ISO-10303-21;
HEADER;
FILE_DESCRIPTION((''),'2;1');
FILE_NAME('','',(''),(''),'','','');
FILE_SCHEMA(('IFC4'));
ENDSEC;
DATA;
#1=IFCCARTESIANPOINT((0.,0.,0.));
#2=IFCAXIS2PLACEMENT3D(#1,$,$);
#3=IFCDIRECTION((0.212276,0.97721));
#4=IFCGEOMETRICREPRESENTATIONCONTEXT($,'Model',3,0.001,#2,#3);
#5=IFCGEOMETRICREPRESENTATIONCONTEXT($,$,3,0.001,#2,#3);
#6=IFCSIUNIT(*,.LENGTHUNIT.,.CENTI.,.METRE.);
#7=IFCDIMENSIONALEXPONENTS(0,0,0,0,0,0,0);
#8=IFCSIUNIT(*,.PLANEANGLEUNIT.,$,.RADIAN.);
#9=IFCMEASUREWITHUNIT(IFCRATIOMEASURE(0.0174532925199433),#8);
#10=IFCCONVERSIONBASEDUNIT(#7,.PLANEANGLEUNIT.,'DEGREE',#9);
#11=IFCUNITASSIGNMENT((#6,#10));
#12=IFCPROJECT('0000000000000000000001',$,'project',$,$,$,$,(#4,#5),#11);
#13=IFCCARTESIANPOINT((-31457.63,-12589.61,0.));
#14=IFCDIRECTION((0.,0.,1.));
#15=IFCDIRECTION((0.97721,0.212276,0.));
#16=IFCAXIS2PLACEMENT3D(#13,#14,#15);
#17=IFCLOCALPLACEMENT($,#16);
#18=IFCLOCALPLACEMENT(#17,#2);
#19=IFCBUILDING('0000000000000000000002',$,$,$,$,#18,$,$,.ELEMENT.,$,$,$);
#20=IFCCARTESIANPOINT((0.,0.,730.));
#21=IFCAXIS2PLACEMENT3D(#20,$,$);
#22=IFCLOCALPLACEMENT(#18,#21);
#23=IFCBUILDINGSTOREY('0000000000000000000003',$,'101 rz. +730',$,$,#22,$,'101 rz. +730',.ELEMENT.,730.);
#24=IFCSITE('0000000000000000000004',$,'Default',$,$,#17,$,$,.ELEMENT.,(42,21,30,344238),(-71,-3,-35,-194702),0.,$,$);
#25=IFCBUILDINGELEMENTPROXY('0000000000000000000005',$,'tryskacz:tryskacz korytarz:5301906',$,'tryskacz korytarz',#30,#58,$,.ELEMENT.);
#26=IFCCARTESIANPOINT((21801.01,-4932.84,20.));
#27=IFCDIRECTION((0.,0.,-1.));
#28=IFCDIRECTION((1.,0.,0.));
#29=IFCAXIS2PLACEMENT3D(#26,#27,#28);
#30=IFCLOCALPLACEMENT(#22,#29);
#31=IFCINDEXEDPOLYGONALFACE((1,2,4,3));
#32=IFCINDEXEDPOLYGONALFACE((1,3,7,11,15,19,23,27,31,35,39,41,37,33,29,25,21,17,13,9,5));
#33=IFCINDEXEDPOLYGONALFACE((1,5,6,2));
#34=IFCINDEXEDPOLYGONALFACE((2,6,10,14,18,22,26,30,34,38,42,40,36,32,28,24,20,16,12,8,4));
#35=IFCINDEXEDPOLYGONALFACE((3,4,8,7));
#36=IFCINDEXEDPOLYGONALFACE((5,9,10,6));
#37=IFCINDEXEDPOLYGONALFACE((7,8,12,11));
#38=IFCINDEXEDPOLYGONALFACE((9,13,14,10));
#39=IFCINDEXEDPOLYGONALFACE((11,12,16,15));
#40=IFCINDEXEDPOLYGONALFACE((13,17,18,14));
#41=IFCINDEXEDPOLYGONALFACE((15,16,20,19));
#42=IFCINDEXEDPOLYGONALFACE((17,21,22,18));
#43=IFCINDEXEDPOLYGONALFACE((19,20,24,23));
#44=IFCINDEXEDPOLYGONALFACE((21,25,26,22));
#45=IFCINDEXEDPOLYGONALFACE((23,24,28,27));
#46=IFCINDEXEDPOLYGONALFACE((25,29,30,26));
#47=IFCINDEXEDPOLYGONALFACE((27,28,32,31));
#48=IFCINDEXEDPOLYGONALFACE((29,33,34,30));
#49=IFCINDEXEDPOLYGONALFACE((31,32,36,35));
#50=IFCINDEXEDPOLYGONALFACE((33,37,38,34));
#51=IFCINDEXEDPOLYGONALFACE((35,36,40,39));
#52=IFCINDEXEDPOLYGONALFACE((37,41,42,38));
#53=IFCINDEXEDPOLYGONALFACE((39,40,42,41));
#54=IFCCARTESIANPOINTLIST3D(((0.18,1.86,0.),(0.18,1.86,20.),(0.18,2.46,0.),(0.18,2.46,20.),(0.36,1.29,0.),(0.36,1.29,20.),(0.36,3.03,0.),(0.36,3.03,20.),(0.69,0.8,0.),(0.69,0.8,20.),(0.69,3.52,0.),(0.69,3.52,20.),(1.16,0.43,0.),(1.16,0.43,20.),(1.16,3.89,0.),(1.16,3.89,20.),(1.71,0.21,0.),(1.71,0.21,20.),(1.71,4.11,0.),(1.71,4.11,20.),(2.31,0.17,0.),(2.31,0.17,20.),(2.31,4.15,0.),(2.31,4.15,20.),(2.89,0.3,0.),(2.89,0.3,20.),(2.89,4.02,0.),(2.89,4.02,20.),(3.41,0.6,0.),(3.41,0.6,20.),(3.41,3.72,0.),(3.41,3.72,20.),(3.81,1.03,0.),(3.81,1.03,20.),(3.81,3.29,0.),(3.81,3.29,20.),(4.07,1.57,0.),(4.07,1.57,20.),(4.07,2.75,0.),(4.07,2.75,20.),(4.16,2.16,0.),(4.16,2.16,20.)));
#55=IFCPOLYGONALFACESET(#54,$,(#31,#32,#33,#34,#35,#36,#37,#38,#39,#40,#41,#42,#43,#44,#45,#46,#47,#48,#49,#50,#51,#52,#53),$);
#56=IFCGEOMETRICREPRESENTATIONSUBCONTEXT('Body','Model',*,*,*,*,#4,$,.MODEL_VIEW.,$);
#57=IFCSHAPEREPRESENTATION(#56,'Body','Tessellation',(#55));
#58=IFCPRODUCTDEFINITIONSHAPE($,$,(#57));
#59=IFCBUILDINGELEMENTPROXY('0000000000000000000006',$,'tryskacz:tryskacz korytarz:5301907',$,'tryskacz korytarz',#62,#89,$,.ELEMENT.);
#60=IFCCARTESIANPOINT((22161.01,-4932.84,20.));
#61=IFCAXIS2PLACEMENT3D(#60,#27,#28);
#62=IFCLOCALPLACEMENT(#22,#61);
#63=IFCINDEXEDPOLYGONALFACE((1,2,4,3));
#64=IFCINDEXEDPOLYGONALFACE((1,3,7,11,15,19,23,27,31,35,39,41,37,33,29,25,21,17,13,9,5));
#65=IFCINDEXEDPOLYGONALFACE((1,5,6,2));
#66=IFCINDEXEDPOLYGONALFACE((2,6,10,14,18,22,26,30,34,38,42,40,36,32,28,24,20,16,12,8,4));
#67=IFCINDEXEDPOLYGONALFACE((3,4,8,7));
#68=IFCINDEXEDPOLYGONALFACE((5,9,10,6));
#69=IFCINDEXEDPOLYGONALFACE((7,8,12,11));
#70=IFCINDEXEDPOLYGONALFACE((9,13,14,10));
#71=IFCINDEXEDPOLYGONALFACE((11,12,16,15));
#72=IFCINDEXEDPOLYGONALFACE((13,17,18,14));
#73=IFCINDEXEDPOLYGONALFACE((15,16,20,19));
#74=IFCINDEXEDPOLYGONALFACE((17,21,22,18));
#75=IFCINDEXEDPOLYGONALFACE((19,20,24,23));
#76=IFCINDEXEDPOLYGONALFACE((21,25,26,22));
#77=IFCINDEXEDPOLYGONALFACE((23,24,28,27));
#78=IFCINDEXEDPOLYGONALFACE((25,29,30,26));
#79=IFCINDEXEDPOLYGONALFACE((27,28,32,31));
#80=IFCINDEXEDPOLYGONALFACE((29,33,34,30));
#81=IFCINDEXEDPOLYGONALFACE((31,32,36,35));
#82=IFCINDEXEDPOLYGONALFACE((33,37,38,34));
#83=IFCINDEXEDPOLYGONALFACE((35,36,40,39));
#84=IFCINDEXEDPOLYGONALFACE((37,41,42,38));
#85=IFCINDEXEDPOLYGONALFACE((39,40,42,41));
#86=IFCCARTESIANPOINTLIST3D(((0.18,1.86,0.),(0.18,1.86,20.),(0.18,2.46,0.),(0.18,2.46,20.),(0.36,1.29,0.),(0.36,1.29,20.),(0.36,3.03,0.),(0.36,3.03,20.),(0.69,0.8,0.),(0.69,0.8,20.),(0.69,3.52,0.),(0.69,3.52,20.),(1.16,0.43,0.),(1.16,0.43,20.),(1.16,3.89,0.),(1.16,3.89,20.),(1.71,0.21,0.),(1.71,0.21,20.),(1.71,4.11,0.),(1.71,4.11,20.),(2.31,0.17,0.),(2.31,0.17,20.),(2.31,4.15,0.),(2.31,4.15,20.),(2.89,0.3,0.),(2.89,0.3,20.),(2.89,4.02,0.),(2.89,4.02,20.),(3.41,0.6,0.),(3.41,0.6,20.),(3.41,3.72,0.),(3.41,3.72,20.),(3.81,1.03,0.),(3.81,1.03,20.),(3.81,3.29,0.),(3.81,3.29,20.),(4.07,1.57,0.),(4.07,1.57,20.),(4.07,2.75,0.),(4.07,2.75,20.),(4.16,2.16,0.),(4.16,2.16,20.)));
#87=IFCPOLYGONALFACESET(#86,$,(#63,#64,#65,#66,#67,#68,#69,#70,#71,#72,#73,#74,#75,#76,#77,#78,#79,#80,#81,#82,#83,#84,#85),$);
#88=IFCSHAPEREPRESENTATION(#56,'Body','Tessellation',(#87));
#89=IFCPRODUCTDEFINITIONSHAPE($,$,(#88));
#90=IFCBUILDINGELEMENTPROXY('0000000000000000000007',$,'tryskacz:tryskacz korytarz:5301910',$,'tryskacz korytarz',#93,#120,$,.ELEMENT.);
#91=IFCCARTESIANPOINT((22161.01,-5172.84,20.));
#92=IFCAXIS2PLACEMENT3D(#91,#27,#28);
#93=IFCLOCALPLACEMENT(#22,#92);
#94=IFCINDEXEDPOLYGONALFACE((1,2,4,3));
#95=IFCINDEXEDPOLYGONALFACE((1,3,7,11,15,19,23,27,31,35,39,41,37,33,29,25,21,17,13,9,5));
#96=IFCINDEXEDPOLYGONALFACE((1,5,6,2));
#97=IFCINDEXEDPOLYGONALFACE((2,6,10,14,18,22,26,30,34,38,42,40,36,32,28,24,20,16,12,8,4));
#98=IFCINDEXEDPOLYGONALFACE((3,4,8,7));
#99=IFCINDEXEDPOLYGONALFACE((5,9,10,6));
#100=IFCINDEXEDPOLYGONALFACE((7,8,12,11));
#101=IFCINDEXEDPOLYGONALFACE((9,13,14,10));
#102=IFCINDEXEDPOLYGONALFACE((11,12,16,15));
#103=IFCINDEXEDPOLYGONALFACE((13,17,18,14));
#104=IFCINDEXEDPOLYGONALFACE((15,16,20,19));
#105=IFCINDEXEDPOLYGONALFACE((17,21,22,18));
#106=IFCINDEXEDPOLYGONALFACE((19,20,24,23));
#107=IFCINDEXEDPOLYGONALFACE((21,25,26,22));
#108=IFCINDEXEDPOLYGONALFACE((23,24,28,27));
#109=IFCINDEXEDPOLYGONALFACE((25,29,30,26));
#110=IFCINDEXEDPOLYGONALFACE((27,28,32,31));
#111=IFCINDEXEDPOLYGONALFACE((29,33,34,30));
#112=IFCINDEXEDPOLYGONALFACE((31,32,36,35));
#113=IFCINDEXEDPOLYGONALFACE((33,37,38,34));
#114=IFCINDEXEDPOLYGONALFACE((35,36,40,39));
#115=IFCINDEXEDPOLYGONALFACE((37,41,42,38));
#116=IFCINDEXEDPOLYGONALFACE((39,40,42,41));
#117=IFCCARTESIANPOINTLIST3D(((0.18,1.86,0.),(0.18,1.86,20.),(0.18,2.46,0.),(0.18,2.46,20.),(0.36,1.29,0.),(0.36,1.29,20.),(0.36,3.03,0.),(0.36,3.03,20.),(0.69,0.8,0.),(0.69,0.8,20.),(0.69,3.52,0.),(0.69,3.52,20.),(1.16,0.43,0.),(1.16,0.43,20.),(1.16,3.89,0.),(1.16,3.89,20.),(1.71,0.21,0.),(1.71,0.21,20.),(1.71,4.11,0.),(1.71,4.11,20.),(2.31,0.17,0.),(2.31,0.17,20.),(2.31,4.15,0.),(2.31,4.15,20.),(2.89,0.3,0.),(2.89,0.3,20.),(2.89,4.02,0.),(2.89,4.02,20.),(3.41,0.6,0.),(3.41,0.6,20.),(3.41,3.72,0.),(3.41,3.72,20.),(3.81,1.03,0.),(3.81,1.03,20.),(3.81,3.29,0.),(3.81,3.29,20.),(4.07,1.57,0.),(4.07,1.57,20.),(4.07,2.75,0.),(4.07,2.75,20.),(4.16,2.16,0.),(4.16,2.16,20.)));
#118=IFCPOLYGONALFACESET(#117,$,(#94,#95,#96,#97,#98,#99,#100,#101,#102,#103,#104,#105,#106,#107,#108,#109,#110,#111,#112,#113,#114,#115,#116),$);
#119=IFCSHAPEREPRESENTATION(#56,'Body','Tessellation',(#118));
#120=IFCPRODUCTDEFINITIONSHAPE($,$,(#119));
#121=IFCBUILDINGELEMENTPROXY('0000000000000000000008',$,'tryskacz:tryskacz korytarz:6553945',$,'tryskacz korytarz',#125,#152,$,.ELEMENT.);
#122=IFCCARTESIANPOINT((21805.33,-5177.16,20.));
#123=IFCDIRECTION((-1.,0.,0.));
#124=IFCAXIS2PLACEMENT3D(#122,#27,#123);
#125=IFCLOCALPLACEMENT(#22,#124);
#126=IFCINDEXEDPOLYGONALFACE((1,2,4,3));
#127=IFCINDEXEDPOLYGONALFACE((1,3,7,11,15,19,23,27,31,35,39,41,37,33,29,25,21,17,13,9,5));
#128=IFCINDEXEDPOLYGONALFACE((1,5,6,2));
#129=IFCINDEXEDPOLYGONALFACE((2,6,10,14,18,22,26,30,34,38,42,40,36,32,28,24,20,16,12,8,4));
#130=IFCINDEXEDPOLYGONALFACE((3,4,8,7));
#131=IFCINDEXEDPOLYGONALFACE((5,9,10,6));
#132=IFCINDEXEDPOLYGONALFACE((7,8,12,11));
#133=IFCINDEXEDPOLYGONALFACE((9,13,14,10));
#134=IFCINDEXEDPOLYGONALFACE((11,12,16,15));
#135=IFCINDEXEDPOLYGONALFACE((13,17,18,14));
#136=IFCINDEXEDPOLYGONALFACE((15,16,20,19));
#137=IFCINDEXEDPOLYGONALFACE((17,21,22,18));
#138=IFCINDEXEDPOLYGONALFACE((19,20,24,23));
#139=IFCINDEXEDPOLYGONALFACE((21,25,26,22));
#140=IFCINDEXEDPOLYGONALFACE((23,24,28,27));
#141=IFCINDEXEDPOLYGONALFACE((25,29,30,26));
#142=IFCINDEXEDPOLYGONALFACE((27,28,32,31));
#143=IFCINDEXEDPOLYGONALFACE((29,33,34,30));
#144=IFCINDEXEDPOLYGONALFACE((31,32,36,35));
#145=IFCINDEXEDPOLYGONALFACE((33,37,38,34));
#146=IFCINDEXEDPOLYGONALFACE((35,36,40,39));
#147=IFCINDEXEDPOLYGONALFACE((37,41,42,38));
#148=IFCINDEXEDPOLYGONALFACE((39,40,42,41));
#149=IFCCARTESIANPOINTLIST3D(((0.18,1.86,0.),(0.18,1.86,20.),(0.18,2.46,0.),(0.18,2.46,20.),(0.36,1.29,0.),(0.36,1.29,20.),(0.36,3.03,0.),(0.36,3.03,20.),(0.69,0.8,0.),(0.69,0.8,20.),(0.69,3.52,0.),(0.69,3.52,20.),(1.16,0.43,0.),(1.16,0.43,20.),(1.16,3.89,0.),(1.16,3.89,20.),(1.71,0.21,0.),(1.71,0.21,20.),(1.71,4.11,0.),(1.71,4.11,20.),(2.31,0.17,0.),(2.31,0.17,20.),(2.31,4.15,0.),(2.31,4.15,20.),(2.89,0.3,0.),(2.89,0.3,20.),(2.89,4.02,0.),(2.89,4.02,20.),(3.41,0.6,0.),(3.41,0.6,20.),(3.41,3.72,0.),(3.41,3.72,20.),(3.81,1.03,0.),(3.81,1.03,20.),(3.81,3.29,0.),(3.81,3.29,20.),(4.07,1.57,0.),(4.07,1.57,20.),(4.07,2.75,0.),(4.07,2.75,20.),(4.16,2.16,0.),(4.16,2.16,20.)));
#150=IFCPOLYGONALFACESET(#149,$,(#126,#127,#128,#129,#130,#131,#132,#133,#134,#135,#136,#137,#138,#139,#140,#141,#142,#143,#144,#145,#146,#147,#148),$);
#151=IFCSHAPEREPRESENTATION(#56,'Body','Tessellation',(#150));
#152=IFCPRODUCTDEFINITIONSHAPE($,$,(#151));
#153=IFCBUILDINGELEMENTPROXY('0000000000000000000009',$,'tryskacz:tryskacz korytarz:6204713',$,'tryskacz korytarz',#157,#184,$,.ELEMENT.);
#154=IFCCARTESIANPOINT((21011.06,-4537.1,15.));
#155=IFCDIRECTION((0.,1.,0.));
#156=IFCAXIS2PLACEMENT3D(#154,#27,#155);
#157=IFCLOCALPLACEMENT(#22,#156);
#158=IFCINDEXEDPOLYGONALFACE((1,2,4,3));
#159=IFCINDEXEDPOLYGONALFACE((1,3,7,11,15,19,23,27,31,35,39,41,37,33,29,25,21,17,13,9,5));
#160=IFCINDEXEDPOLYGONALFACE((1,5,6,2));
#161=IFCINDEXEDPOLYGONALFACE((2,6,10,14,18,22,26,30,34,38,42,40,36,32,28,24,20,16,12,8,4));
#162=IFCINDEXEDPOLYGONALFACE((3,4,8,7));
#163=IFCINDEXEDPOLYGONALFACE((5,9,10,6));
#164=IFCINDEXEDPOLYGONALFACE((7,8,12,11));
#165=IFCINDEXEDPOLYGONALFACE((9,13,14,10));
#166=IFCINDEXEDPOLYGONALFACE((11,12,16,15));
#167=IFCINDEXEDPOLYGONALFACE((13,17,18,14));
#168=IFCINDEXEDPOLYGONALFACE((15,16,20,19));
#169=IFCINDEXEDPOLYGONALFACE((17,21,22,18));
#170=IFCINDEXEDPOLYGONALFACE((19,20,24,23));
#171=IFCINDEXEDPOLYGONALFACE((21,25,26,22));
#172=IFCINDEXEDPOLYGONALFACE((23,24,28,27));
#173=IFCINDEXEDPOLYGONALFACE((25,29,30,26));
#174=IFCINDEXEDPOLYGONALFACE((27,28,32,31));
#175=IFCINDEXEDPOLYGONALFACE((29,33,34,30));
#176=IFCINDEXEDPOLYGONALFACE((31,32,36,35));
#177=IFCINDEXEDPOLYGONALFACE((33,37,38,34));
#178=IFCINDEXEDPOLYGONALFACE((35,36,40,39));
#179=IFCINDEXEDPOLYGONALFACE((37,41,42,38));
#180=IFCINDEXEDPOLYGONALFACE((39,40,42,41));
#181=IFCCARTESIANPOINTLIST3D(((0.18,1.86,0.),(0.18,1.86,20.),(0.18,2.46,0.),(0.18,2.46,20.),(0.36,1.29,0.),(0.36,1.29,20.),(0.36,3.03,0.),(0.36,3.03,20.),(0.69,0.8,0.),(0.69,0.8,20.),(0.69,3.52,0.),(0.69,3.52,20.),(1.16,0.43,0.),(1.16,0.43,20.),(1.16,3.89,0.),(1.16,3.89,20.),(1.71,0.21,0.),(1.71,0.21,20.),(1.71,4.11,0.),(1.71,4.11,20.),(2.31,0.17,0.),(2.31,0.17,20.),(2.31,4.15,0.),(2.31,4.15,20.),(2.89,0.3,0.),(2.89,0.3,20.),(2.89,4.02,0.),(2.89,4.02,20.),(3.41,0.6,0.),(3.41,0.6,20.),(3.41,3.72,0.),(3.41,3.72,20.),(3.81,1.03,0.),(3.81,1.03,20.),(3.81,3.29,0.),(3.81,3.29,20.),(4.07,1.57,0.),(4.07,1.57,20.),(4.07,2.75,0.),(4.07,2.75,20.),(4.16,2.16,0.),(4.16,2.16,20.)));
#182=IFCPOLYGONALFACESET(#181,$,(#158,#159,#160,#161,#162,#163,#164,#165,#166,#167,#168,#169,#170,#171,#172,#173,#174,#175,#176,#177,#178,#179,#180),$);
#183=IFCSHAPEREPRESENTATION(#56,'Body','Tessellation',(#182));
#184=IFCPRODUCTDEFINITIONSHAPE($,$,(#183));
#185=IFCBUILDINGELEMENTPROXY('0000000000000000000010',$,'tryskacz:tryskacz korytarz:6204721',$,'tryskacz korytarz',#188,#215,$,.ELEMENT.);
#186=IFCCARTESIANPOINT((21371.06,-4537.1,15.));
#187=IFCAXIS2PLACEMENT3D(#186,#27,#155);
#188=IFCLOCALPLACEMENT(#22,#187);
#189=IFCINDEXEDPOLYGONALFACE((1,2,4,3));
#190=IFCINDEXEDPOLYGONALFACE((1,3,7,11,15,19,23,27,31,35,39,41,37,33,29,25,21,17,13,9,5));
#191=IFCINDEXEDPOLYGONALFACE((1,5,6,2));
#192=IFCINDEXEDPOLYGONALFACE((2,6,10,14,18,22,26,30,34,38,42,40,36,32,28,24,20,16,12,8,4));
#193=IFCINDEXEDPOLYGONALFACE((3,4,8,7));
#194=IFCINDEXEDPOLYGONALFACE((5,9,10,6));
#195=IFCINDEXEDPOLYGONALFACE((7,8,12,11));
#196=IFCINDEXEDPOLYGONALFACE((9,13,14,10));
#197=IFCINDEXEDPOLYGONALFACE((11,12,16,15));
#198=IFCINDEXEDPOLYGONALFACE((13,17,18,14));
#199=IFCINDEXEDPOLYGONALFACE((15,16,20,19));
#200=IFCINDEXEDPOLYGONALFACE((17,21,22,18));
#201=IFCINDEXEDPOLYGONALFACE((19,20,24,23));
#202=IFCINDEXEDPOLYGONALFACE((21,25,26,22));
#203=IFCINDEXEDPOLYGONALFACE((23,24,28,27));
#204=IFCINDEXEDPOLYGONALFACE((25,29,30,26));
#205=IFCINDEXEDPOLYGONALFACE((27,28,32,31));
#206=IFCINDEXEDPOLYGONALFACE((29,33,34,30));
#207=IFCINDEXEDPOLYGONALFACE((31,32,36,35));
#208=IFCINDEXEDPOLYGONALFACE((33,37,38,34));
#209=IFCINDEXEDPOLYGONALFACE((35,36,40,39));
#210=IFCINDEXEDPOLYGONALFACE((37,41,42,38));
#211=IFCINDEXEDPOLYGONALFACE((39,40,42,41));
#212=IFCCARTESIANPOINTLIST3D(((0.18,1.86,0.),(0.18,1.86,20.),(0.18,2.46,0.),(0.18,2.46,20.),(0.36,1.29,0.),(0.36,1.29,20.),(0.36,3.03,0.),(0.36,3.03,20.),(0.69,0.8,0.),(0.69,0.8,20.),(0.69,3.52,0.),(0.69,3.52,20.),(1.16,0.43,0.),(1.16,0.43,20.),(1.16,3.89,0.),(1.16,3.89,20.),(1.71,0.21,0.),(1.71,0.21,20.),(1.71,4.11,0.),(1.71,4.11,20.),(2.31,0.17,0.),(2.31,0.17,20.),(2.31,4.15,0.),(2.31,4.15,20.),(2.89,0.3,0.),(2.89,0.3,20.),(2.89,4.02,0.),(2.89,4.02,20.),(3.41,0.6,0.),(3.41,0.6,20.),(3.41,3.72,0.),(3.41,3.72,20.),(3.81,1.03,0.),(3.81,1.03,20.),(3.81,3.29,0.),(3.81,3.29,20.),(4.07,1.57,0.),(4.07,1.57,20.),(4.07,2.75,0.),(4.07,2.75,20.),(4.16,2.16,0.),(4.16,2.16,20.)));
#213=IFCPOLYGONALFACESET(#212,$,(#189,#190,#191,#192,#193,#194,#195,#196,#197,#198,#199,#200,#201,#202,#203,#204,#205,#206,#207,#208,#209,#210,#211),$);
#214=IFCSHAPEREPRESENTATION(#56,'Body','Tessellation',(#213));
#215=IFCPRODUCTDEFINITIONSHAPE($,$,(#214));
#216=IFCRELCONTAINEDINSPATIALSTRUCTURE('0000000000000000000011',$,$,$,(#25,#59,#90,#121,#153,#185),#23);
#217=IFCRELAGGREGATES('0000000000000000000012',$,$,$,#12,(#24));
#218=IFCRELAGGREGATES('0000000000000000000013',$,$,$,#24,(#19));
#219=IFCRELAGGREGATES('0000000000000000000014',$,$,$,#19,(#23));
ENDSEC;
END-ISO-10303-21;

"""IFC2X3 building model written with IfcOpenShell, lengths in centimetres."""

from ifc_helpers import new_model, entity, si_unit, converted_unit, direction, frame, frame_2d, origin, place, context, subcontext, project, spatial, circle, extrude, source, transform, mapped, element, save


model = new_model("IFC2X3")

# Units and contexts
model_context = context("Model", 3, precision=0.001, world=origin(), true_north=direction((0.212276, 0.97721)))
context_of_model = context(None, 3, precision=0.001, world=origin(), true_north=direction((0.212276, 0.97721)))
body_context = subcontext(model_context, "Body", "Model", "MODEL_VIEW")
ifc_project = project(units=[si_unit("LENGTHUNIT", "METRE", prefix="CENTI"), converted_unit("PLANEANGLEUNIT", "DEGREE", entity("IfcRatioMeasure", 0.0174532925199433), si_unit("PLANEANGLEUNIT", "RADIAN"), dimensions=[0, 0, 0, 0, 0, 0, 0])], contexts=[model_context, context_of_model])

# Site, building, storey
site_placement = place(None, frame((-31457.63, -12589.61, 0.0), z_axis=(0.0, 0.0, 1.0), x_axis=(0.97721, 0.212276, 0.0)))
site = spatial("IfcSite", under=ifc_project, at=site_placement, Name="Default", CompositionType="ELEMENT", RefLatitude=(42, 21, 30, 344238), RefLongitude=(-71, -3, -35, -194702), RefElevation=0.0)
building_placement = place(site_placement, origin())
building = spatial("IfcBuilding", under=site, at=building_placement, CompositionType="ELEMENT")
storey_placement = place(building_placement, frame((0.0, 0.0, 730.0)))
storey = spatial("IfcBuildingStorey", under=building, at=storey_placement, Name="101 rz. +730", LongName="101 rz. +730", CompositionType="ELEMENT", Elevation=730.0)

# Building element proxies
shared_shape_1 = source(origin(), body_context, "Body", "SweptSolid", [
    extrude(circle(Radius=2.0, at=frame_2d((0.0, 0.0), x_axis=(1.0, 0.0))), frame((2.16, 2.16, 0.0)), (0.0, 0.0, 1.0), 20.0),
])
for number, where, z_axis, x_axis, name in (
    (1, (21801.01, -4932.84, 20.0), (0.0, 0.0, -1.0), (1.0, 0.0, 0.0), "tryskacz:tryskacz korytarz:5301906"),
    (2, (22161.01, -4932.84, 20.0), (0.0, 0.0, -1.0), (1.0, 0.0, 0.0), "tryskacz:tryskacz korytarz:5301907"),
    (3, (22161.01, -5172.84, 20.0), (0.0, 0.0, -1.0), (1.0, 0.0, 0.0), "tryskacz:tryskacz korytarz:5301910"),
    (4, (21805.33, -5177.16, 20.0), (0.0, 0.0, -1.0), (-1.0, 0.0, 0.0), "tryskacz:tryskacz korytarz:6553945"),
):
    element("IfcBuildingElementProxy", number, at=place(storey_placement, frame(where, z_axis=z_axis, x_axis=x_axis)), inside=storey, Name=name, ObjectType="tryskacz korytarz", CompositionType="ELEMENT", context=body_context, shape_type="MappedRepresentation", body=[
        mapped(shared_shape_1, transform((0.0, 0.0, 0.0), scale=1.0)),
    ])
shared_shape_2 = source(origin(), body_context, "Body", "SweptSolid", [
    extrude(circle(Radius=2.0, at=frame_2d((0.0, 0.0), x_axis=(1.0, 0.0))), frame((2.16, 2.16, 0.0)), (0.0, 0.0, 1.0), 20.0),
])
for number, where, z_axis, x_axis, name in (
    (5, (21011.06, -4537.1, 15.0), (0.0, 0.0, -1.0), (0.0, 1.0, 0.0), "tryskacz:tryskacz korytarz:6204713"),
    (6, (21371.06, -4537.1, 15.0), (0.0, 0.0, -1.0), (0.0, 1.0, 0.0), "tryskacz:tryskacz korytarz:6204721"),
):
    element("IfcBuildingElementProxy", number, at=place(storey_placement, frame(where, z_axis=z_axis, x_axis=x_axis)), inside=storey, Name=name, ObjectType="tryskacz korytarz", CompositionType="ELEMENT", context=body_context, shape_type="MappedRepresentation", body=[
        mapped(shared_shape_2, transform((0.0, 0.0, 0.0), scale=1.0)),
    ])

save(model, "model.ifc")
